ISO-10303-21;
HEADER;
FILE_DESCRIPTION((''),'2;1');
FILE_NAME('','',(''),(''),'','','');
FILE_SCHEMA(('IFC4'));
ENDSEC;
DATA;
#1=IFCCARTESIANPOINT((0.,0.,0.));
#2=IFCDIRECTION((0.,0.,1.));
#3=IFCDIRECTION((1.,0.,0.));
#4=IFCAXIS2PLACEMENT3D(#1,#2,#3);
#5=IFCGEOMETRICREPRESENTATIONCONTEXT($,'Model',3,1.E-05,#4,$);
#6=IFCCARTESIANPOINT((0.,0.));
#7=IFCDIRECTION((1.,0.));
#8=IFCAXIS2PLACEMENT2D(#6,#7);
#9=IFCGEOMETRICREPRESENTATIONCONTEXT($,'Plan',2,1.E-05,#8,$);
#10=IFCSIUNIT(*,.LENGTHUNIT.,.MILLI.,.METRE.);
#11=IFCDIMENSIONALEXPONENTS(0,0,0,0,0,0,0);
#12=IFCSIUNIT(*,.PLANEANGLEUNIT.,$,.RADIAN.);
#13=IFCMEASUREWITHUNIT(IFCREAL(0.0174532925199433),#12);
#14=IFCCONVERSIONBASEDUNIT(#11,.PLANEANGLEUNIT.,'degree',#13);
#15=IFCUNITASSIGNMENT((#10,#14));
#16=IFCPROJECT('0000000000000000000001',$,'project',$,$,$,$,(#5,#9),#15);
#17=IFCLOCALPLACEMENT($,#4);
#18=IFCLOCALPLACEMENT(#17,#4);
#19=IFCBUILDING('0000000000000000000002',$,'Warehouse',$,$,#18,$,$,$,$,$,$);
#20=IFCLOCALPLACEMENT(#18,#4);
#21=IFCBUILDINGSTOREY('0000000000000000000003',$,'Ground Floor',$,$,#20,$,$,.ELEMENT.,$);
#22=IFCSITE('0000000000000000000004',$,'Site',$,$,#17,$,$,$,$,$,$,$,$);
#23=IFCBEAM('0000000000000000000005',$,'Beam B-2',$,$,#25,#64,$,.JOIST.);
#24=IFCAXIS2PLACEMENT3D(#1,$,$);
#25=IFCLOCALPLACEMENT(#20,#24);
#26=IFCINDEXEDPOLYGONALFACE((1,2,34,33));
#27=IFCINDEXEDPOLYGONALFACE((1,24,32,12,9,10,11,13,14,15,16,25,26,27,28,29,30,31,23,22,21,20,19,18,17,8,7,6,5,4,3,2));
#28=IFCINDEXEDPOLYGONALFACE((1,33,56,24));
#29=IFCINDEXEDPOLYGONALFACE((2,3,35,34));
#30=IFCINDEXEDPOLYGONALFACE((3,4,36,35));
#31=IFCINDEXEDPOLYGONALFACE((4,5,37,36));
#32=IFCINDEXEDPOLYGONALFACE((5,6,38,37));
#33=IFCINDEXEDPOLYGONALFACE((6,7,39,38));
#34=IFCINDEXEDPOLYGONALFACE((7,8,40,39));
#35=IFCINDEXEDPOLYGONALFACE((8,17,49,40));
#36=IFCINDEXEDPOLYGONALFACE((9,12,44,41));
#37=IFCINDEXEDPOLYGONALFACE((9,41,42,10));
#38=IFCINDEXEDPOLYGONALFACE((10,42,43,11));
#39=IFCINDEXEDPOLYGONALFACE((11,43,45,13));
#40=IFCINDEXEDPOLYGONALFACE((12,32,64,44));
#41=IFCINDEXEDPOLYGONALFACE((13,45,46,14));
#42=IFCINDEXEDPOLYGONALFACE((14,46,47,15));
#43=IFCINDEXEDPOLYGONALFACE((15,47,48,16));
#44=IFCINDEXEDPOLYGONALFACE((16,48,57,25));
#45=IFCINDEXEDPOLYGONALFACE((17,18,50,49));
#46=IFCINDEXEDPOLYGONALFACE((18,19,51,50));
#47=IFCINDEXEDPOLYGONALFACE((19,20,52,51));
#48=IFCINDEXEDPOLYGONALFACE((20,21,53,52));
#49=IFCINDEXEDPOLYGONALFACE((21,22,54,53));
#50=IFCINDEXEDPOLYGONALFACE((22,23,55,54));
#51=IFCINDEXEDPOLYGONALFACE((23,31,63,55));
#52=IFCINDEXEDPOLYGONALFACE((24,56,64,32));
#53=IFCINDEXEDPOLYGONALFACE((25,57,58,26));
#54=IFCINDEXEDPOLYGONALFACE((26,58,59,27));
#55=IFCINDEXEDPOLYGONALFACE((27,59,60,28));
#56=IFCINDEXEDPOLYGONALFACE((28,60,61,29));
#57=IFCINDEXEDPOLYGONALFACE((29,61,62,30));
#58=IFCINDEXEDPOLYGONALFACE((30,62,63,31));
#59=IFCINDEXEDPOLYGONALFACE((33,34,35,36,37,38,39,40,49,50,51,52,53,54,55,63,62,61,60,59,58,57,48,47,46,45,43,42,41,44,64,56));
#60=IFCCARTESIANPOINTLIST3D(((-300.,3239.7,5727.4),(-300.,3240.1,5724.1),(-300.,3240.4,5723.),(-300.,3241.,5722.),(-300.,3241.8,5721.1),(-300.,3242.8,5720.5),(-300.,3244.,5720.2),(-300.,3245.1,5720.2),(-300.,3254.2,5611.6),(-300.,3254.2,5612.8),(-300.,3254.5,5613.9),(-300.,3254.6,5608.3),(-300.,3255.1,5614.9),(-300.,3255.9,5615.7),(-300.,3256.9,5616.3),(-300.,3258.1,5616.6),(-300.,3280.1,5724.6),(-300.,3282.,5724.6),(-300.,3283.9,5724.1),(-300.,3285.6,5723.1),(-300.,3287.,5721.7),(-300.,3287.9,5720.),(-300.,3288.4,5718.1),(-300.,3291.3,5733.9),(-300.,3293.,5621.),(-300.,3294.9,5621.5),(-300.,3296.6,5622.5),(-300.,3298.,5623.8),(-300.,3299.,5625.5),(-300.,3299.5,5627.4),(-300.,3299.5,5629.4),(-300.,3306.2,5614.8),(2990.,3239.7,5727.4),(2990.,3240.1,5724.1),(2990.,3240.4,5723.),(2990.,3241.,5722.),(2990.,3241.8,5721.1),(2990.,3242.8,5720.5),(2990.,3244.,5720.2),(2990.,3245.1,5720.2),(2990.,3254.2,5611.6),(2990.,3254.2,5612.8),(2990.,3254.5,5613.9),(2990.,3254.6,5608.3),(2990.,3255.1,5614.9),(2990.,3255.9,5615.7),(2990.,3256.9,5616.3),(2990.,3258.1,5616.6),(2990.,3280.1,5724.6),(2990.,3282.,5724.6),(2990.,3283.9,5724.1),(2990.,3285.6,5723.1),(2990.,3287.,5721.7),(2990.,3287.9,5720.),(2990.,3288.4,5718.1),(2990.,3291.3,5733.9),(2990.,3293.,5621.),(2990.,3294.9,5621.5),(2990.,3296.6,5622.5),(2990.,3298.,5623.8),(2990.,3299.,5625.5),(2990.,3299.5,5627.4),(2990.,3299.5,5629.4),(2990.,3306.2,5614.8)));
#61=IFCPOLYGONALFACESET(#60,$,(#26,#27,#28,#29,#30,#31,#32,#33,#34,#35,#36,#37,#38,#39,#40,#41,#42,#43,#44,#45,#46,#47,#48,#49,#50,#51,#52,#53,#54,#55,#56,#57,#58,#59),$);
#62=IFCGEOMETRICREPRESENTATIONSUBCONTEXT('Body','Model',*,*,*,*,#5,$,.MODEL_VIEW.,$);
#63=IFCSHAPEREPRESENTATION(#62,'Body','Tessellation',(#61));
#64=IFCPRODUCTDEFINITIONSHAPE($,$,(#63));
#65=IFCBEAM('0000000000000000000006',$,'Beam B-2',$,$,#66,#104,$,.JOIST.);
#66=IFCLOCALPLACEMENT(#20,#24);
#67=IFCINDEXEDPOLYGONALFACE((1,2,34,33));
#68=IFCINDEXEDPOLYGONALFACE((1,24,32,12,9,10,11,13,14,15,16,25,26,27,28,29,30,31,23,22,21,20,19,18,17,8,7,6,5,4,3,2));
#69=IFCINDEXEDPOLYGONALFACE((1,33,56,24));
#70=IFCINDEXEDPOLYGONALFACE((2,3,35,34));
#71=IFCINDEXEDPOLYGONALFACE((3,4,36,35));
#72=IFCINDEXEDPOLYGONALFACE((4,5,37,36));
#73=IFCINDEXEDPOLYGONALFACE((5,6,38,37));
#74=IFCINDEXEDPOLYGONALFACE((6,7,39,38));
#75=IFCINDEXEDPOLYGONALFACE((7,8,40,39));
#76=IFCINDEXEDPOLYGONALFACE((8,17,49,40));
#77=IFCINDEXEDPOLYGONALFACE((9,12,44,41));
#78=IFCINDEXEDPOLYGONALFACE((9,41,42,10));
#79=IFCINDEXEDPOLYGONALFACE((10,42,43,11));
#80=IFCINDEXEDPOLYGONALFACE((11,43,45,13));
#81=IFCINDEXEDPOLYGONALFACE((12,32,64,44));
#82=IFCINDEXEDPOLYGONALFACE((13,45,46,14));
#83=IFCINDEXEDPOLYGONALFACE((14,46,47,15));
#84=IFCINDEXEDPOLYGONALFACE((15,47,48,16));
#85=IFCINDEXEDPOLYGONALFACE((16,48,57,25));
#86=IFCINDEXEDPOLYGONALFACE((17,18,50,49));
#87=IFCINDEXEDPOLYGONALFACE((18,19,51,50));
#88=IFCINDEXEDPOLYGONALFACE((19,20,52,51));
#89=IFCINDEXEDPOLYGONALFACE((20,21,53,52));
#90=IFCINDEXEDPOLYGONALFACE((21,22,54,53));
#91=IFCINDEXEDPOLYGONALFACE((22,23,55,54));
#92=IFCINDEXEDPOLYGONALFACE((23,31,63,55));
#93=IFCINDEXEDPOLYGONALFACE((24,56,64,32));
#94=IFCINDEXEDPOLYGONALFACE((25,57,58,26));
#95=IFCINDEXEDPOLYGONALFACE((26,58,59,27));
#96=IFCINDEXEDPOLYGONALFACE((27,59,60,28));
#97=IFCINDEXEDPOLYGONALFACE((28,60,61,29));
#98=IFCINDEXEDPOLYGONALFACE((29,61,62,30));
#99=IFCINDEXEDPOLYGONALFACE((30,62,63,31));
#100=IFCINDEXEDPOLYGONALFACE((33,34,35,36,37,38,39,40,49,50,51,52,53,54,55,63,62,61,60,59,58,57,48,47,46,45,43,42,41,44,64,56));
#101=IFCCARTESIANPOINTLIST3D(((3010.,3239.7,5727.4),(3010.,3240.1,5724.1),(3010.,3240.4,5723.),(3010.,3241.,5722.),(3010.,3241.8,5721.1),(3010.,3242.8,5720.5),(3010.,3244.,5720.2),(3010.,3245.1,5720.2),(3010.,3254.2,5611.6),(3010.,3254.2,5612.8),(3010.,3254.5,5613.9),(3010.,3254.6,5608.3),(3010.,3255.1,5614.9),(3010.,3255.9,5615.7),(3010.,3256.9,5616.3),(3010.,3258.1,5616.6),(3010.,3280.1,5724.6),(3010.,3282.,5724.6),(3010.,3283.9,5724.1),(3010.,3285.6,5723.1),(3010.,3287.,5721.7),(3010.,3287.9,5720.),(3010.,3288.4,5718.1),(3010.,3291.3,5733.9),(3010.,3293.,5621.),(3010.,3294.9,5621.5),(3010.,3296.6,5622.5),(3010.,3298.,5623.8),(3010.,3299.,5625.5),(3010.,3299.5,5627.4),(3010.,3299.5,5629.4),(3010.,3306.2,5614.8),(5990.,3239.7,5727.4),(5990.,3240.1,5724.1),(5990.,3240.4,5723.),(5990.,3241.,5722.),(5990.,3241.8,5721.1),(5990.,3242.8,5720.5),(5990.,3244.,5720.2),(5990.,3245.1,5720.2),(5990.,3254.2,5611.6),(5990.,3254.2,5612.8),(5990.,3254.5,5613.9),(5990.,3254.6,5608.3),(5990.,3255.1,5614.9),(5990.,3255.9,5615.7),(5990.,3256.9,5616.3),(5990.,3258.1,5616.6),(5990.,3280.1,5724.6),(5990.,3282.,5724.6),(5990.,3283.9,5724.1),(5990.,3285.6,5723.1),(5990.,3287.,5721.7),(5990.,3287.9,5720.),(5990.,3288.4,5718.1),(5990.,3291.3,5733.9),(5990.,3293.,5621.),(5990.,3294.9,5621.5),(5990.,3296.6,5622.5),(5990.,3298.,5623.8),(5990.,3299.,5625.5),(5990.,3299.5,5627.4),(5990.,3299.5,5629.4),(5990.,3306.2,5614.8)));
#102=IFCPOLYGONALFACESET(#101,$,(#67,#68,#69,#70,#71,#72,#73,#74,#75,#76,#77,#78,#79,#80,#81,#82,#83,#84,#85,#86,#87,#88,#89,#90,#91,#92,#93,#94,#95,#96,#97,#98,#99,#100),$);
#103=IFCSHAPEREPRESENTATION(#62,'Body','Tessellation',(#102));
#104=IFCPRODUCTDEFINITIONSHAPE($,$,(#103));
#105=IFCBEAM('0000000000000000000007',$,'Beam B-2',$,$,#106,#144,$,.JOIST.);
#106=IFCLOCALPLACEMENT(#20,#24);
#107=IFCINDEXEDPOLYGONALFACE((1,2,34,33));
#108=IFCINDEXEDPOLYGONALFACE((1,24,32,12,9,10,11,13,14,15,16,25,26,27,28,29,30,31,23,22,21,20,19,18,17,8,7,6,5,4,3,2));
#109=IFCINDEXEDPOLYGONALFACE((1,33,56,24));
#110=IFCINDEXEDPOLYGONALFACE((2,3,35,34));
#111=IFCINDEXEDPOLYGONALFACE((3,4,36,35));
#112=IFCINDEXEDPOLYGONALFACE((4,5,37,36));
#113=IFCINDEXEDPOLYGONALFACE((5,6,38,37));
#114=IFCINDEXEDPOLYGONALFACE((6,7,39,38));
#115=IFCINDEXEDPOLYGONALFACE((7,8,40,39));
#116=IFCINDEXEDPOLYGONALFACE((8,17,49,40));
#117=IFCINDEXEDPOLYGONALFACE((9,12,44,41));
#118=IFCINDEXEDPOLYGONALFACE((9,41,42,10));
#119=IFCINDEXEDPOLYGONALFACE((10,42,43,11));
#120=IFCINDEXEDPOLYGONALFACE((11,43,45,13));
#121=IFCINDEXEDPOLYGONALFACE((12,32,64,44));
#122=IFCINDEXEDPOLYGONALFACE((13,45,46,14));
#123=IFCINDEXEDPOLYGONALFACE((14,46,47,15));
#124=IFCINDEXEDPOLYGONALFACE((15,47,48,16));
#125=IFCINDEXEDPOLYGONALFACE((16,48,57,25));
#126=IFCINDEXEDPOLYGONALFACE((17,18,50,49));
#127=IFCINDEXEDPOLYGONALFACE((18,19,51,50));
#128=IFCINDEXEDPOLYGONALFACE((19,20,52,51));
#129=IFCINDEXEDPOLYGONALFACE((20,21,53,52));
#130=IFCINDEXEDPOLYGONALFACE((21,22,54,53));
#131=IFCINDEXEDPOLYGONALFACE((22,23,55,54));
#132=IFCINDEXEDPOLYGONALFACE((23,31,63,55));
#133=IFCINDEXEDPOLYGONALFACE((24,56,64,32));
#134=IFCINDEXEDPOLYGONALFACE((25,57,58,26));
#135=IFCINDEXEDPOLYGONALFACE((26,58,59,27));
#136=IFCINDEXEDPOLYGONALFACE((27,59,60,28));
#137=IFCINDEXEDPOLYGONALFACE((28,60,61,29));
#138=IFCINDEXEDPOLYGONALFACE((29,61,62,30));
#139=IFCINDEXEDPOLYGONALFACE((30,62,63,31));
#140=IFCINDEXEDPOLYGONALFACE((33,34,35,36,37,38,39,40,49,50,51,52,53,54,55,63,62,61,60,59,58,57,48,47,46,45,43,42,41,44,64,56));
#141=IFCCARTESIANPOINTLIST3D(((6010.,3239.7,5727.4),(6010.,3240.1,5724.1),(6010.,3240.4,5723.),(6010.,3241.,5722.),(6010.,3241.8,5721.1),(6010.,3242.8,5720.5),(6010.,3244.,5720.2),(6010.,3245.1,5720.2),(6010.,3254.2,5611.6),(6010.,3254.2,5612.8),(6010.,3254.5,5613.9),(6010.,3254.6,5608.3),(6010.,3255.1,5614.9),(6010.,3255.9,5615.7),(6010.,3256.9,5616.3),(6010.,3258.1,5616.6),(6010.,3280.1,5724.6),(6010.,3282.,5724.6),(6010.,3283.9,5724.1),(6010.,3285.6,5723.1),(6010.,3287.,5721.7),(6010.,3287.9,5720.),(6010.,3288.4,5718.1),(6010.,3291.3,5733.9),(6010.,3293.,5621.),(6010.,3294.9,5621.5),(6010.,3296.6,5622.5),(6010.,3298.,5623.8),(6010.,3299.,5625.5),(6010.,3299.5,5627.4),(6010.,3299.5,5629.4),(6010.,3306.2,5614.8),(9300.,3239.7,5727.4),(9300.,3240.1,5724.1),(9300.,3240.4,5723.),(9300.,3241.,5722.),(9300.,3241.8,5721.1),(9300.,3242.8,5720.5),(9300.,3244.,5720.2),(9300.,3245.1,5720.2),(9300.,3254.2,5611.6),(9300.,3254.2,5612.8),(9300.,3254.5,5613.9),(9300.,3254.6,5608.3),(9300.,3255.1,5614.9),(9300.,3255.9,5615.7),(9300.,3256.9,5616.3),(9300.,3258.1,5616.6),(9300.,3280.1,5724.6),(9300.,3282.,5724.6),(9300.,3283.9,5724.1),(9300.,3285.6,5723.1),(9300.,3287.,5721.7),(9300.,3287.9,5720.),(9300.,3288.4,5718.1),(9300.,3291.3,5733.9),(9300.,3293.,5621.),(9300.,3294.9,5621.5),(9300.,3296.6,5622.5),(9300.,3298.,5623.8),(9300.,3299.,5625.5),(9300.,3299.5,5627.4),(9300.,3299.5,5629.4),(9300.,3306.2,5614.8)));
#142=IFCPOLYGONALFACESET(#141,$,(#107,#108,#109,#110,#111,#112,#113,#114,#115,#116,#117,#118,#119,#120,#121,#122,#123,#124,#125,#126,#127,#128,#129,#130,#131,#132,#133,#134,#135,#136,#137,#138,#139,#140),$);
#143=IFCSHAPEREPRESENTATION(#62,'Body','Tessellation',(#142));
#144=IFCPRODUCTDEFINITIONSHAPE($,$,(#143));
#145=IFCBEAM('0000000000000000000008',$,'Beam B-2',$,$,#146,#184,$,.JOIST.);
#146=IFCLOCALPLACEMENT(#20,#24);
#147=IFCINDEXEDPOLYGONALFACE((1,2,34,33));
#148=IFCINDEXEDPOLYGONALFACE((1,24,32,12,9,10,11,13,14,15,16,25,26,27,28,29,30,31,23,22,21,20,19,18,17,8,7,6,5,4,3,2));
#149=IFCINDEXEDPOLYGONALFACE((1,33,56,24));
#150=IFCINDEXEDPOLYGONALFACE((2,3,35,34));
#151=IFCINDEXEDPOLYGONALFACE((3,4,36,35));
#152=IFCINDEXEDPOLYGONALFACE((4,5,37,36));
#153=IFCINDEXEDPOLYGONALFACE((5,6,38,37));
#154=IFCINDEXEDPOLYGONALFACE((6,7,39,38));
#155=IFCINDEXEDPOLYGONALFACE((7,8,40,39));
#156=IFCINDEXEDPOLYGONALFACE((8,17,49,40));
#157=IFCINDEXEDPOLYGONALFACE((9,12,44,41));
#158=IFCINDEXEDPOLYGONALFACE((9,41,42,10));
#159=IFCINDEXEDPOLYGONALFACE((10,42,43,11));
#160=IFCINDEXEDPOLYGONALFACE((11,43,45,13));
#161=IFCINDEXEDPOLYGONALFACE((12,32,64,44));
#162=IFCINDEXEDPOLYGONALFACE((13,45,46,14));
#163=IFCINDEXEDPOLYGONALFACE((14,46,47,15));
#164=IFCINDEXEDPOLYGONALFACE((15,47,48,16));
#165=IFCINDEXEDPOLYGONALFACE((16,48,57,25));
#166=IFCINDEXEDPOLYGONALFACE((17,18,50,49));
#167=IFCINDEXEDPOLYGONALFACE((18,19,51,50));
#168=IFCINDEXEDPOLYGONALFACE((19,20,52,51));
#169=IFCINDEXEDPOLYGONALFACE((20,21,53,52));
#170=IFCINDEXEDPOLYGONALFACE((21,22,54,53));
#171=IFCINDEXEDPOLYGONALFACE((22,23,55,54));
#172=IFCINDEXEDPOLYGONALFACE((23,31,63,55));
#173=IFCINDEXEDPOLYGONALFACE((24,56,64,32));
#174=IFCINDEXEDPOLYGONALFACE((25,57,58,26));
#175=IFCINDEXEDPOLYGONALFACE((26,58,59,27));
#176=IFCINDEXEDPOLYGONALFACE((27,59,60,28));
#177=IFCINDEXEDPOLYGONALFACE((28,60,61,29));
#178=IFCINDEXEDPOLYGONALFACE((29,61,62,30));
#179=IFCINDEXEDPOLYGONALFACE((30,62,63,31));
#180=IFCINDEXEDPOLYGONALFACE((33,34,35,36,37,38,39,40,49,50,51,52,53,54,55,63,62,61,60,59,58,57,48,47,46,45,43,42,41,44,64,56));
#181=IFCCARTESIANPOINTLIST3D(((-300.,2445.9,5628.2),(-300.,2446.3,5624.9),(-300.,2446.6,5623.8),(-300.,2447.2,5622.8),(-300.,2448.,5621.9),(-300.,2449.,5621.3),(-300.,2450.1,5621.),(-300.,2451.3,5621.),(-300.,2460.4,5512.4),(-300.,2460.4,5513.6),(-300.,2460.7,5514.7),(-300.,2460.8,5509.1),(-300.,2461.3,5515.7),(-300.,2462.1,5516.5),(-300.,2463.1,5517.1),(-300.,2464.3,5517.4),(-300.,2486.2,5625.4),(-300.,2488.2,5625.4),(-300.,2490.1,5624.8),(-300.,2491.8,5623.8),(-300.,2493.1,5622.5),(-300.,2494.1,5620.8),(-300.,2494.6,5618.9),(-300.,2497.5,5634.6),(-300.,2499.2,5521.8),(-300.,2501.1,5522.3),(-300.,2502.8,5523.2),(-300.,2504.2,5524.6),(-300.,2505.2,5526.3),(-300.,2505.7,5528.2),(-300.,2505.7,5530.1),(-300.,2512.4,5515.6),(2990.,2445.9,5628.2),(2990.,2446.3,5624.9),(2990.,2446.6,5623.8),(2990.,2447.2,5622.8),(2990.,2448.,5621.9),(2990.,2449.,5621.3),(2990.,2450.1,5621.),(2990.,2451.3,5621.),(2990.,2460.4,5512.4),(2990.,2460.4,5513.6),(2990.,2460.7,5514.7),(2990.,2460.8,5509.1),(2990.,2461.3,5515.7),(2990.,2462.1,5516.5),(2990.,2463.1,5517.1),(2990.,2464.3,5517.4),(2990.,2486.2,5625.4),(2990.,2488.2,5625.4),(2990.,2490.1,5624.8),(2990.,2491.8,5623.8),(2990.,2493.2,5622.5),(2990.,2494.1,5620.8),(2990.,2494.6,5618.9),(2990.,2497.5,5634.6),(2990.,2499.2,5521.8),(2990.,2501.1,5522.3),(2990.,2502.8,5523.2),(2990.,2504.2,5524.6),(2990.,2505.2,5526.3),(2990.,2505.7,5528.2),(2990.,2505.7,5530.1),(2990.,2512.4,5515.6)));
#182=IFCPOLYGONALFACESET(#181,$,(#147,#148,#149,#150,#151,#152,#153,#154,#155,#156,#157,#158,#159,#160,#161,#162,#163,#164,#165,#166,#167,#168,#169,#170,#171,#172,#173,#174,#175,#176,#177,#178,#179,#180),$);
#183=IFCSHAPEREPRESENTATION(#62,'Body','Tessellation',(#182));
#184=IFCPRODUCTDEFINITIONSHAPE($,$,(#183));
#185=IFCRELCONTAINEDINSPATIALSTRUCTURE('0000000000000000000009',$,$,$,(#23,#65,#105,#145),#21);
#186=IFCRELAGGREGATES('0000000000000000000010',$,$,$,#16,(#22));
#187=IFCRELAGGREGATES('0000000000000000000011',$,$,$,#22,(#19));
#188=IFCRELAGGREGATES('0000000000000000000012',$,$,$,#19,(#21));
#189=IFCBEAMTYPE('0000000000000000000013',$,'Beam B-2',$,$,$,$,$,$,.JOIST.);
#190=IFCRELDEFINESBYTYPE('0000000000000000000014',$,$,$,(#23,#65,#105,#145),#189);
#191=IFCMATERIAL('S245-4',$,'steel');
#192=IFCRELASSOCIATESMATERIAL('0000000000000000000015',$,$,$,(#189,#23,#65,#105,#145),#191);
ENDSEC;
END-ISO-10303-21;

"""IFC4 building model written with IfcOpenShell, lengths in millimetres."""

from ifc_helpers import new_model, entity, si_unit, converted_unit, frame, origin_with_axes, origin_2d_with_axis, place, context, subcontext, project, spatial, u_section, extrude, material, material_profile, profile_set, profile_usage, type_object, element, save


model = new_model("IFC4")

# Units and contexts
model_context = context("Model", 3, precision=1e-05, world=origin_with_axes())
plan_context = context("Plan", 2, precision=1e-05, world=origin_2d_with_axis())
body_context = subcontext(model_context, "Body", "Model", "MODEL_VIEW")
ifc_project = project(units=[si_unit("LENGTHUNIT", "METRE", prefix="MILLI"), converted_unit("PLANEANGLEUNIT", "degree", entity("IfcReal", 0.0174532925199433), si_unit("PLANEANGLEUNIT", "RADIAN"), dimensions=[0, 0, 0, 0, 0, 0, 0])], contexts=[model_context, plan_context])

# Site, building, storey
site_placement = place(None, origin_with_axes())
site = spatial("IfcSite", under=ifc_project, at=site_placement, Name="Site")
building_placement = place(site_placement, origin_with_axes())
building = spatial("IfcBuilding", under=site, at=building_placement, Name="Warehouse")
storey_placement = place(building_placement, origin_with_axes())
storey = spatial("IfcBuildingStorey", under=building, at=storey_placement, Name="Ground Floor", CompositionType="ELEMENT")

# Beams
ifc_material_1 = material(Name="S245-4", Category="steel")
ifc_material_profile_1 = material_profile(ifc_material_1, u_section(Depth=120.0, FlangeWidth=52.0, WebThickness=4.8, FlangeThickness=7.8, FilletRadius=7.5, EdgeRadius=4.5, FlangeSlope=0.0))
ifc_profile_set_1 = profile_set([ifc_material_profile_1], Name="U12P_S245-4")
beam_type_1 = type_object("IfcBeamType", Name="Beam B-2", PredefinedType="JOIST", material=ifc_profile_set_1)
ifc_profile_usage_1 = profile_usage(ifc_profile_set_1, cardinal=3)
beam_1_placement = place(storey_placement, frame((2990.0, 3306.2, 5614.8), z_axis=(-1.0, 0.0, 0.0), x_axis=(0.0, -0.99228, -0.124019)))
element("IfcBeam", 1, at=beam_1_placement, inside=storey, type_object=beam_type_1, material=ifc_profile_usage_1, Name="Beam B-2", PredefinedType="JOIST", context=body_context, shape_type="SweptSolid", body=[
    extrude(u_section(Depth=120.0, FlangeWidth=52.0, WebThickness=4.8, FlangeThickness=7.8, FilletRadius=7.5, EdgeRadius=4.5, FlangeSlope=0.0), frame((26.0, 60.0, 0.0), z_axis=(0.0, 0.0, 1.0), x_axis=(1.0, 0.0, 0.0)), (0.0, 0.0, 1.0), 3290.0),
])
ifc_profile_usage_2 = profile_usage(ifc_profile_set_1, cardinal=3)
beam_2_placement = place(storey_placement, frame((5990.0, 3306.2, 5614.8), z_axis=(-1.0, 0.0, 0.0), x_axis=(0.0, -0.99228, -0.12402)))
element("IfcBeam", 2, at=beam_2_placement, inside=storey, type_object=beam_type_1, material=ifc_profile_usage_2, Name="Beam B-2", PredefinedType="JOIST", context=body_context, shape_type="SweptSolid", body=[
    extrude(u_section(Depth=120.0, FlangeWidth=52.0, WebThickness=4.8, FlangeThickness=7.8, FilletRadius=7.5, EdgeRadius=4.5, FlangeSlope=0.0), frame((26.0, 60.0, 0.0), z_axis=(0.0, 0.0, 1.0), x_axis=(1.0, 0.0, 0.0)), (0.0, 0.0, 1.0), 2980.0),
])
ifc_profile_usage_3 = profile_usage(ifc_profile_set_1, cardinal=3)
beam_3_placement = place(storey_placement, frame((9300.0, 3306.2, 5614.8), z_axis=(-1.0, 0.0, 0.0), x_axis=(0.0, -0.99228, -0.12402)))
element("IfcBeam", 3, at=beam_3_placement, inside=storey, type_object=beam_type_1, material=ifc_profile_usage_3, Name="Beam B-2", PredefinedType="JOIST", context=body_context, shape_type="SweptSolid", body=[
    extrude(u_section(Depth=120.0, FlangeWidth=52.0, WebThickness=4.8, FlangeThickness=7.8, FilletRadius=7.5, EdgeRadius=4.5, FlangeSlope=0.0), frame((26.0, 60.0, 0.0), z_axis=(0.0, 0.0, 1.0), x_axis=(1.0, 0.0, 0.0)), (0.0, 0.0, 1.0), 3290.0),
])
ifc_profile_usage_4 = profile_usage(ifc_profile_set_1, cardinal=3)
beam_4_placement = place(storey_placement, frame((2990.0, 2512.4, 5515.6), z_axis=(-1.0, 0.0, 0.0), x_axis=(0.0, -0.99228, -0.124019)))
element("IfcBeam", 4, at=beam_4_placement, inside=storey, type_object=beam_type_1, material=ifc_profile_usage_4, Name="Beam B-2", PredefinedType="JOIST", context=body_context, shape_type="SweptSolid", body=[
    extrude(u_section(Depth=120.0, FlangeWidth=52.0, WebThickness=4.8, FlangeThickness=7.8, FilletRadius=7.5, EdgeRadius=4.5, FlangeSlope=0.0), frame((26.0, 60.0, 0.0), z_axis=(0.0, 0.0, 1.0), x_axis=(1.0, 0.0, 0.0)), (0.0, 0.0, 1.0), 3290.0),
])

save(model, "model.ifc")
